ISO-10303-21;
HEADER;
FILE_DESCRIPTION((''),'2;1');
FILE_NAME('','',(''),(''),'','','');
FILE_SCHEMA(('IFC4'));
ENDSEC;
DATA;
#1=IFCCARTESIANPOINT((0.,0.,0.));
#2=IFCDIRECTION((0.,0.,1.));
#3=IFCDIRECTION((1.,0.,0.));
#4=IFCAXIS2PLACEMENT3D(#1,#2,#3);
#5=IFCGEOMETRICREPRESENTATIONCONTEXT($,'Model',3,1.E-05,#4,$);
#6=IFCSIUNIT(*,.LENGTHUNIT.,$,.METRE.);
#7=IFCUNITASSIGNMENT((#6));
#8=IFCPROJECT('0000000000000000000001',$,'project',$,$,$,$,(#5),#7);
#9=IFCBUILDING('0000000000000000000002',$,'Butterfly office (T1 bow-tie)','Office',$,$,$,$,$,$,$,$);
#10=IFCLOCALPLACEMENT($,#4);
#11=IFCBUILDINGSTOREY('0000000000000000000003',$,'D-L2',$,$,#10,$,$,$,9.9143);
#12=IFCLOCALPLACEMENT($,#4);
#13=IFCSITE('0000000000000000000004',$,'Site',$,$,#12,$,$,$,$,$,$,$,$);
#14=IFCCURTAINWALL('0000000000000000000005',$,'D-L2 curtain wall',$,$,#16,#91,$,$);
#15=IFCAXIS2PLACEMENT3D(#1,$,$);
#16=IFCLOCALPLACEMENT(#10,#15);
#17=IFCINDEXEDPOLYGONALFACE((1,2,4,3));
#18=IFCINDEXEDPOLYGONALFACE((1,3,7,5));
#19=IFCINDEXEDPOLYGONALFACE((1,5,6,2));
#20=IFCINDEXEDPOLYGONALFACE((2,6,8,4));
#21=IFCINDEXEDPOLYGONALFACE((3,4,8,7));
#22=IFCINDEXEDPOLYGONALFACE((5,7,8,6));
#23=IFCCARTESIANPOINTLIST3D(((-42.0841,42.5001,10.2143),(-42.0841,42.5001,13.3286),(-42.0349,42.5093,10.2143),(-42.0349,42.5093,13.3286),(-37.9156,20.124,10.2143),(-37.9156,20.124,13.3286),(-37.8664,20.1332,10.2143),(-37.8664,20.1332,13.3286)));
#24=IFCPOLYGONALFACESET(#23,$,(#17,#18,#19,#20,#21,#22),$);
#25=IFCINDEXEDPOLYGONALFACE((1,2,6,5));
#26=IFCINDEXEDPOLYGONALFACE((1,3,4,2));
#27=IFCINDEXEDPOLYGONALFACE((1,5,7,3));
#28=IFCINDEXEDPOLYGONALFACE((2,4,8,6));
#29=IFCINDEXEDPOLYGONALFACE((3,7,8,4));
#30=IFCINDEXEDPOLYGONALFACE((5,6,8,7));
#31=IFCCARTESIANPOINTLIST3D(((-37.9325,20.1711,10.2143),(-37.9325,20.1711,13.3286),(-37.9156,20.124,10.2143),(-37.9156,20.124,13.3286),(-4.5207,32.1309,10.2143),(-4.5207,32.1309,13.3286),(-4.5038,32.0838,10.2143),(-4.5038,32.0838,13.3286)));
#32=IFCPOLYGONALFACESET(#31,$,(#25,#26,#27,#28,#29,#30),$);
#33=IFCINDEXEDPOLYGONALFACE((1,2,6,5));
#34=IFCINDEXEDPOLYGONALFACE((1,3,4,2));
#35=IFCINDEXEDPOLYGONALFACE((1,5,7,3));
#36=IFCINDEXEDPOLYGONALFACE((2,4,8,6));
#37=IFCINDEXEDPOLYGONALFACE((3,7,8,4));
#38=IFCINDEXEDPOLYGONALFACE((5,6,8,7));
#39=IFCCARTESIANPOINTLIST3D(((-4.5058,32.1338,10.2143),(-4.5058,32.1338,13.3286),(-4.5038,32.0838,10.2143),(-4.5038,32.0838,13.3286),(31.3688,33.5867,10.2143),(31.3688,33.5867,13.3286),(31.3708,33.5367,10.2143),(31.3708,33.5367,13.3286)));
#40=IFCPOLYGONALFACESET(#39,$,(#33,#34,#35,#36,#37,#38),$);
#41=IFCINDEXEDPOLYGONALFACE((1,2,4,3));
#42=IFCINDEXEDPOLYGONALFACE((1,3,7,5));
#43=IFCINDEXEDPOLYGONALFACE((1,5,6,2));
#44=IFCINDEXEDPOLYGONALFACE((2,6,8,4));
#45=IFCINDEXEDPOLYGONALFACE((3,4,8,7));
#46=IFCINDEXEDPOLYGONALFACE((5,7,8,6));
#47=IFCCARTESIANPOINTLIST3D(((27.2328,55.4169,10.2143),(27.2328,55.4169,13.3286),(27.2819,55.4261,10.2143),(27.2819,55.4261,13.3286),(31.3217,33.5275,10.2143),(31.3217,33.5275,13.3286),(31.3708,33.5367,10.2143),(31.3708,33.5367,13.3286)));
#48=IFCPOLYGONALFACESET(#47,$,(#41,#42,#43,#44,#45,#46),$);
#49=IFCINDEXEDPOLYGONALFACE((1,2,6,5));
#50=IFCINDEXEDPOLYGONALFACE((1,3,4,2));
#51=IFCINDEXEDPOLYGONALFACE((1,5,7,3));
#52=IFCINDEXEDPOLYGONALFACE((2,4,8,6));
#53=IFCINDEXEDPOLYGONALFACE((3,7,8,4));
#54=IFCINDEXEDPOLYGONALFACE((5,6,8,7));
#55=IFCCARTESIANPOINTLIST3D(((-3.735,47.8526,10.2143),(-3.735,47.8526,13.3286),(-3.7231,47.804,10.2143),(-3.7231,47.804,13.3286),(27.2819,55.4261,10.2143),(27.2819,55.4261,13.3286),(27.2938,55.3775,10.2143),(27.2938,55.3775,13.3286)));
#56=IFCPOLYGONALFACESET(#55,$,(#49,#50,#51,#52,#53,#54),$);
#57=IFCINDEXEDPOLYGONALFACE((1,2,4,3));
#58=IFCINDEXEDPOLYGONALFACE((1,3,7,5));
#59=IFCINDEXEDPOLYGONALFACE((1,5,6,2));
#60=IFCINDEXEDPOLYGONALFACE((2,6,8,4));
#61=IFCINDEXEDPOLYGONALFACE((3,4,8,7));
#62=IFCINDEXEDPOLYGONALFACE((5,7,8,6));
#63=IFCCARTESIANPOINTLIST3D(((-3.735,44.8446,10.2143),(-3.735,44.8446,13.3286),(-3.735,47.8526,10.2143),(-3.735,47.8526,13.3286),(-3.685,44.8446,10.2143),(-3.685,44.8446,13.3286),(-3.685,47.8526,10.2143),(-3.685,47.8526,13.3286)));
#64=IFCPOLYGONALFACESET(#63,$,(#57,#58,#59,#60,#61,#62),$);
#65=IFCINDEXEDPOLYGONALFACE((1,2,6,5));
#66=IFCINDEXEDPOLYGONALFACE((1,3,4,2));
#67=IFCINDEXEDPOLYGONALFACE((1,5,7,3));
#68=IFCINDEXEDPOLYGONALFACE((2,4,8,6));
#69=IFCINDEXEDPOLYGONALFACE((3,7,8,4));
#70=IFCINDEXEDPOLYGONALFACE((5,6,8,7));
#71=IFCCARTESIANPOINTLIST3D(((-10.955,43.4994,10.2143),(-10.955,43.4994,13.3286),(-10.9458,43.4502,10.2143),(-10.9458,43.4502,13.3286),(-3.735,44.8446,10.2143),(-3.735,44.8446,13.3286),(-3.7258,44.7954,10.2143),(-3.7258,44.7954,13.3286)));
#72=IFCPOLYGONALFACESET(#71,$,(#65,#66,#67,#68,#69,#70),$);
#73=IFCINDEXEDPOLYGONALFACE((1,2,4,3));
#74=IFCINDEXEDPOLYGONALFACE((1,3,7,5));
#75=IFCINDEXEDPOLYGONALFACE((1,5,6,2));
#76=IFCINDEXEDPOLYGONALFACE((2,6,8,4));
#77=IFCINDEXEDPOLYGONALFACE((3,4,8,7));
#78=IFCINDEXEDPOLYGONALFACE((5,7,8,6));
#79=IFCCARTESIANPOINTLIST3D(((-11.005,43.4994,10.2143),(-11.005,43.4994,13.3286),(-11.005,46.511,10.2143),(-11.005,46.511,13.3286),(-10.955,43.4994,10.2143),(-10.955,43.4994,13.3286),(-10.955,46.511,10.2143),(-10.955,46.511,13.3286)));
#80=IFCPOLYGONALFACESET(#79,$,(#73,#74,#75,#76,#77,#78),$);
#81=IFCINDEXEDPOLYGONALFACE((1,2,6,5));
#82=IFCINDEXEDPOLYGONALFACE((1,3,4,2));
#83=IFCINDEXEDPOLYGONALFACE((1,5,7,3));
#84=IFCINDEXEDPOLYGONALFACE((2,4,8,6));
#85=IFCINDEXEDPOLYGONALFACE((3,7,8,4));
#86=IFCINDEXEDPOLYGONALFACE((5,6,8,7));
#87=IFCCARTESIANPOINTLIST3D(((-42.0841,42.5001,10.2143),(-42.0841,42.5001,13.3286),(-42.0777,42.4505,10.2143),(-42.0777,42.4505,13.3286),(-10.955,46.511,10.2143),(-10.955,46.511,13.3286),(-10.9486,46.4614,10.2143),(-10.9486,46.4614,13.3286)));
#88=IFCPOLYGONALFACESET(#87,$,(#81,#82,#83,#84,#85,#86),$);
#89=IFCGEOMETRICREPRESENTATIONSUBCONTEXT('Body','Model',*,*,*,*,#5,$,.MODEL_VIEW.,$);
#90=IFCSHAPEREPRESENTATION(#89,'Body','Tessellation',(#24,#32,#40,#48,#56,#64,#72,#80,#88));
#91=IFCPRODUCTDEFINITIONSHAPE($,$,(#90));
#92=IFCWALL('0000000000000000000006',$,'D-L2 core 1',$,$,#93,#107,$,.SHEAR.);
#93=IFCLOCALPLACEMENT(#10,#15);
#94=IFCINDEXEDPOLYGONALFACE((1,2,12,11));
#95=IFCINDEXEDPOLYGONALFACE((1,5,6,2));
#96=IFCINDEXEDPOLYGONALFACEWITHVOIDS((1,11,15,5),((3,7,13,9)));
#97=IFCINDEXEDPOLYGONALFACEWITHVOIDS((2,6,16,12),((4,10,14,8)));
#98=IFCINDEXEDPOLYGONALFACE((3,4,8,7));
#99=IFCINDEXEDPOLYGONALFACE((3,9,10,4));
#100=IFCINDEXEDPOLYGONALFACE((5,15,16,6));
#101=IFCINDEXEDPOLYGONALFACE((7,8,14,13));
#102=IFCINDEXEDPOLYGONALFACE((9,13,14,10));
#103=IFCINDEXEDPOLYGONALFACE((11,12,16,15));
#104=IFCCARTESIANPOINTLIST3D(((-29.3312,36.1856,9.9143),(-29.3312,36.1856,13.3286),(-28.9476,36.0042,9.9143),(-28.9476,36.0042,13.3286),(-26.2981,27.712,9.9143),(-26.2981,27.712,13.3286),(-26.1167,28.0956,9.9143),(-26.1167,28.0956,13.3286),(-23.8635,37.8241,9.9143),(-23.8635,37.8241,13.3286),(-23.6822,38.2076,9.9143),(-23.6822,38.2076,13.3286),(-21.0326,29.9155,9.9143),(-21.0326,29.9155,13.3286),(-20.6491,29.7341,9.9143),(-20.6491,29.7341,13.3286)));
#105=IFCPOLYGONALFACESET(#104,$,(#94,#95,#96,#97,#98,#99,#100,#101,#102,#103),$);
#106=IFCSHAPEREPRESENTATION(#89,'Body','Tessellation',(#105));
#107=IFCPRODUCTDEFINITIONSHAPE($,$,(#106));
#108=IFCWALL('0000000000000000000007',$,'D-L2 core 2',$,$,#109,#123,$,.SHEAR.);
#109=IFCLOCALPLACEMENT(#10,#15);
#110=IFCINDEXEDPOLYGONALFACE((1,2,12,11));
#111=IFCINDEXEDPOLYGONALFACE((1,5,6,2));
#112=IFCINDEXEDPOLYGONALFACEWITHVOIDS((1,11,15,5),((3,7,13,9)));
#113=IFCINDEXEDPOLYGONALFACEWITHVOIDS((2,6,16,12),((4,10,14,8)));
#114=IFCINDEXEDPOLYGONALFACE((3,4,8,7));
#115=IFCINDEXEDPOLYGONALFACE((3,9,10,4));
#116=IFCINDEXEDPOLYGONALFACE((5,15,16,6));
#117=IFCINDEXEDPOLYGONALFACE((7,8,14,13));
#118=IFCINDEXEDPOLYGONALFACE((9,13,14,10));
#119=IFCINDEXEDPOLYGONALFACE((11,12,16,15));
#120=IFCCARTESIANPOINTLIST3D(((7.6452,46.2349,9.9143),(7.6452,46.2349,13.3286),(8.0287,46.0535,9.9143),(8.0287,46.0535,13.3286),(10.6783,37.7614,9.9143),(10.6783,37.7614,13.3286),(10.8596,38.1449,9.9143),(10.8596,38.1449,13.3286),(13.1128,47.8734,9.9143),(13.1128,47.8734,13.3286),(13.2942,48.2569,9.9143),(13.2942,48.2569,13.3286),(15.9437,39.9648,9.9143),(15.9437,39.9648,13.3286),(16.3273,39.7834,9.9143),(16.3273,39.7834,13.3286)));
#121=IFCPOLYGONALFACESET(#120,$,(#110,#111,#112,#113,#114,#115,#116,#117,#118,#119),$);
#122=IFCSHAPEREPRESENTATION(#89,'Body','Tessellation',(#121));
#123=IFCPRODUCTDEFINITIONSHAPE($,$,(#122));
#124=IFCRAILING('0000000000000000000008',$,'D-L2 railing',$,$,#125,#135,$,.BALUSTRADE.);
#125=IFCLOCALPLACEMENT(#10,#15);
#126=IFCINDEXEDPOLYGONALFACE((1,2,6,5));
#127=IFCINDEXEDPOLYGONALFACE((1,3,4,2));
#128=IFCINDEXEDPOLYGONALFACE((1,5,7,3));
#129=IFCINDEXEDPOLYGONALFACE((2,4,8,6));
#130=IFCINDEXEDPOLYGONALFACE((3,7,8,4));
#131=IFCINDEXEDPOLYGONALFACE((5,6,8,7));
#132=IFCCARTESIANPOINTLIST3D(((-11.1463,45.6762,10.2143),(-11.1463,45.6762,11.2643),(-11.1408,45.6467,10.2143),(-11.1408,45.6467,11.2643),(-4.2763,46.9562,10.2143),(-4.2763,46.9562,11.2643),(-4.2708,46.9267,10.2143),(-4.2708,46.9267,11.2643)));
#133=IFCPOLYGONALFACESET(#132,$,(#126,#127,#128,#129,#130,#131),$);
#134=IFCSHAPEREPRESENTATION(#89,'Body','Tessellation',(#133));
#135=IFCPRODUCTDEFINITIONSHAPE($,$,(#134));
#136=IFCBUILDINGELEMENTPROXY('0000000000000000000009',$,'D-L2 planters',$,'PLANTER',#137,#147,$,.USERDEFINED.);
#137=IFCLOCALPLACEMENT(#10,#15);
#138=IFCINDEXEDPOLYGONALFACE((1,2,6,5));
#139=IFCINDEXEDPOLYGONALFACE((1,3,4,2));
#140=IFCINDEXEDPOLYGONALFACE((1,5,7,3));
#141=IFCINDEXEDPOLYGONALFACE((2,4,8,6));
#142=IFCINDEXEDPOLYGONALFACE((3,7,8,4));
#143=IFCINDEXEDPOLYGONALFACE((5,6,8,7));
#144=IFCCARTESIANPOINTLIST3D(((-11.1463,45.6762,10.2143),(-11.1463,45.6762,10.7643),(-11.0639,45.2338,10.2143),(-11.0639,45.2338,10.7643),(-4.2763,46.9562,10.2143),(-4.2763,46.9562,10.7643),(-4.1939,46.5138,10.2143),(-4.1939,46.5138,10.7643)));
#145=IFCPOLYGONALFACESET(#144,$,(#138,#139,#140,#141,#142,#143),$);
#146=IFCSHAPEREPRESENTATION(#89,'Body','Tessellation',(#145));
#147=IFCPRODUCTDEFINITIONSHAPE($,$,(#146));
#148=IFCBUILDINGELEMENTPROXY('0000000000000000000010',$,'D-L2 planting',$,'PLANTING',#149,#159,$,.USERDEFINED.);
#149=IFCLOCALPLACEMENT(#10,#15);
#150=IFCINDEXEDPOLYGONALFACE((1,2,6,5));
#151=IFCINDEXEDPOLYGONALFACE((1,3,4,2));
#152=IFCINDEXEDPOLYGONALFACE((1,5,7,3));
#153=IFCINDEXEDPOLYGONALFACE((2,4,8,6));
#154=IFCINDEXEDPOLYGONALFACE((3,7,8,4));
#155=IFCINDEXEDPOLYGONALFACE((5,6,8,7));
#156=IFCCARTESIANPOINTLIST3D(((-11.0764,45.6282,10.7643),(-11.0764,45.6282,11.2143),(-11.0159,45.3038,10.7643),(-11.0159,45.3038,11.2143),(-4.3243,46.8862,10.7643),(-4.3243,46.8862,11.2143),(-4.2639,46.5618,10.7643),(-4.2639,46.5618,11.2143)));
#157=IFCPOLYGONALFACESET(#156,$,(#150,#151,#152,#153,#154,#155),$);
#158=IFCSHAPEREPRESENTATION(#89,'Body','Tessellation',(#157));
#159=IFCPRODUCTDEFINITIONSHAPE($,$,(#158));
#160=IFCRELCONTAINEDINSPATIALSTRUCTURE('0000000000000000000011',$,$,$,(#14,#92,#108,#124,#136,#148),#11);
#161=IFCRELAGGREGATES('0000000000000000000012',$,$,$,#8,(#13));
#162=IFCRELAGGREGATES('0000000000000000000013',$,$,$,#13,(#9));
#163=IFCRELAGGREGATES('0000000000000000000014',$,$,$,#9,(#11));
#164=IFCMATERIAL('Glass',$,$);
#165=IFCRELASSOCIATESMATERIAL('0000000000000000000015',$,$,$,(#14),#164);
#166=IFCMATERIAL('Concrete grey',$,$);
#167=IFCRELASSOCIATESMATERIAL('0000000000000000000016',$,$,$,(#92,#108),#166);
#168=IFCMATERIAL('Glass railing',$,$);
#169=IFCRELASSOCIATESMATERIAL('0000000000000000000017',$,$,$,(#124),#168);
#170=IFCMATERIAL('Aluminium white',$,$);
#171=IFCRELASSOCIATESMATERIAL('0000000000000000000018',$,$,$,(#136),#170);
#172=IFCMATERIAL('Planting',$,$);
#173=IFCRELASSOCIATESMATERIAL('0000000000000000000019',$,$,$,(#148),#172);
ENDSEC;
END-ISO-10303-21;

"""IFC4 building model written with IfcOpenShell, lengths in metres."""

from ifc_helpers import new_model, si_unit, frame, origin_with_axes, place, context, subcontext, project, spatial, polyline, outline, extrude, material, element, save


model = new_model("IFC4")

# Units and contexts
model_context = context("Model", 3, precision=1e-05, world=origin_with_axes())
body_context = subcontext(model_context, "Body", "Model", "MODEL_VIEW")
ifc_project = project(units=[si_unit("LENGTHUNIT", "METRE")], contexts=[model_context])

# Site, building, storey
site_placement = place(None, origin_with_axes())
site = spatial("IfcSite", under=ifc_project, at=site_placement, Name="Site")
building = spatial("IfcBuilding", under=site, Name="Butterfly office (T1 bow-tie)", Description="Office")
storey_placement = place(None, origin_with_axes())
storey = spatial("IfcBuildingStorey", under=building, at=storey_placement, Name="D-L2", Elevation=9.9143)

# Shared definitions
ifc_material_1 = material(Name="Concrete grey")

# Shared definitions
ifc_material_2 = material(Name="Aluminium white")

# Curtain wall
ifc_material_3 = material(Name="Glass")
curtain_wall_placement = place(storey_placement, origin_with_axes())
element("IfcCurtainWall", 1, at=curtain_wall_placement, inside=storey, material=ifc_material_3, Name="D-L2 curtain wall", context=body_context, shape_type="SweptSolid", body=[
    extrude(outline(polyline([(-42.0841, 42.5001), (-37.9156, 20.124), (-37.8664, 20.1332), (-42.0349, 42.5093), (-42.0841, 42.5001)])), frame((0.0, 0.0, 10.2143), z_axis=(0.0, 0.0, 1.0), x_axis=(1.0, 0.0, 0.0)), (0.0, 0.0, 1.0), 3.1143),
    extrude(outline(polyline([(-37.9156, 20.124), (-4.5038, 32.0838), (-4.5207, 32.1309), (-37.9325, 20.1711), (-37.9156, 20.124)])), frame((0.0, 0.0, 10.2143), z_axis=(0.0, 0.0, 1.0), x_axis=(1.0, 0.0, 0.0)), (0.0, 0.0, 1.0), 3.1143),
    extrude(outline(polyline([(-4.5038, 32.0838), (31.3708, 33.5367), (31.3688, 33.5867), (-4.5058, 32.1338), (-4.5038, 32.0838)])), frame((0.0, 0.0, 10.2143), z_axis=(0.0, 0.0, 1.0), x_axis=(1.0, 0.0, 0.0)), (0.0, 0.0, 1.0), 3.1143),
    extrude(outline(polyline([(31.3708, 33.5367), (27.2819, 55.4261), (27.2328, 55.4169), (31.3217, 33.5275), (31.3708, 33.5367)])), frame((0.0, 0.0, 10.2143), z_axis=(0.0, 0.0, 1.0), x_axis=(1.0, 0.0, 0.0)), (0.0, 0.0, 1.0), 3.1143),
    extrude(outline(polyline([(27.2819, 55.4261), (-3.735, 47.8526), (-3.7231, 47.804), (27.2938, 55.3775), (27.2819, 55.4261)])), frame((0.0, 0.0, 10.2143), z_axis=(0.0, 0.0, 1.0), x_axis=(1.0, 0.0, 0.0)), (0.0, 0.0, 1.0), 3.1143),
    extrude(outline(polyline([(-3.735, 47.8526), (-3.735, 44.8446), (-3.685, 44.8446), (-3.685, 47.8526), (-3.735, 47.8526)])), frame((0.0, 0.0, 10.2143), z_axis=(0.0, 0.0, 1.0), x_axis=(1.0, 0.0, 0.0)), (0.0, 0.0, 1.0), 3.1143),
    extrude(outline(polyline([(-3.735, 44.8446), (-10.955, 43.4994), (-10.9458, 43.4502), (-3.7258, 44.7954), (-3.735, 44.8446)])), frame((0.0, 0.0, 10.2143), z_axis=(0.0, 0.0, 1.0), x_axis=(1.0, 0.0, 0.0)), (0.0, 0.0, 1.0), 3.1143),
    extrude(outline(polyline([(-10.955, 43.4994), (-10.955, 46.511), (-11.005, 46.511), (-11.005, 43.4994), (-10.955, 43.4994)])), frame((0.0, 0.0, 10.2143), z_axis=(0.0, 0.0, 1.0), x_axis=(1.0, 0.0, 0.0)), (0.0, 0.0, 1.0), 3.1143),
    extrude(outline(polyline([(-10.955, 46.511), (-42.0841, 42.5001), (-42.0777, 42.4505), (-10.9486, 46.4614), (-10.955, 46.511)])), frame((0.0, 0.0, 10.2143), z_axis=(0.0, 0.0, 1.0), x_axis=(1.0, 0.0, 0.0)), (0.0, 0.0, 1.0), 3.1143),
])

# Walls
wall_1_placement = place(storey_placement, origin_with_axes())
element("IfcWall", 2, at=wall_1_placement, inside=storey, material=ifc_material_1, Name="D-L2 core 1", PredefinedType="SHEAR", context=body_context, shape_type="SweptSolid", body=[
    extrude(outline(polyline([(-26.2981, 27.712), (-20.6491, 29.7341), (-23.6822, 38.2076), (-29.3312, 36.1856), (-26.2981, 27.712)]), holes=[polyline([(-26.1167, 28.0956), (-21.0326, 29.9155), (-23.8635, 37.8241), (-28.9476, 36.0042), (-26.1167, 28.0956)])]), frame((0.0, 0.0, 9.9143), z_axis=(0.0, 0.0, 1.0), x_axis=(1.0, 0.0, 0.0)), (0.0, 0.0, 1.0), 3.4143),
])
wall_2_placement = place(storey_placement, origin_with_axes())
element("IfcWall", 3, at=wall_2_placement, inside=storey, material=ifc_material_1, Name="D-L2 core 2", PredefinedType="SHEAR", context=body_context, shape_type="SweptSolid", body=[
    extrude(outline(polyline([(10.6783, 37.7614), (16.3273, 39.7834), (13.2942, 48.2569), (7.6452, 46.2349), (10.6783, 37.7614)]), holes=[polyline([(10.8596, 38.1449), (15.9437, 39.9648), (13.1128, 47.8734), (8.0287, 46.0535), (10.8596, 38.1449)])]), frame((0.0, 0.0, 9.9143), z_axis=(0.0, 0.0, 1.0), x_axis=(1.0, 0.0, 0.0)), (0.0, 0.0, 1.0), 3.4143),
])

# Railing
ifc_material_4 = material(Name="Glass railing")
railing_placement = place(storey_placement, origin_with_axes())
element("IfcRailing", 4, at=railing_placement, inside=storey, material=ifc_material_4, Name="D-L2 railing", PredefinedType="BALUSTRADE", context=body_context, shape_type="SweptSolid", body=[
    extrude(outline(polyline([(-4.2763, 46.9562), (-11.1463, 45.6762), (-11.1408, 45.6467), (-4.2708, 46.9267), (-4.2763, 46.9562)])), frame((0.0, 0.0, 10.2143), z_axis=(0.0, 0.0, 1.0), x_axis=(1.0, 0.0, 0.0)), (0.0, 0.0, 1.0), 1.05),
])

# Building element proxies
proxy_1_placement = place(storey_placement, origin_with_axes())
element("IfcBuildingElementProxy", 5, at=proxy_1_placement, inside=storey, material=ifc_material_2, Name="D-L2 planters", ObjectType="PLANTER", PredefinedType="USERDEFINED", context=body_context, shape_type="SweptSolid", body=[
    extrude(outline(polyline([(-4.2763, 46.9562), (-11.1463, 45.6762), (-11.0639, 45.2338), (-4.1939, 46.5138), (-4.2763, 46.9562)])), frame((0.0, 0.0, 10.2143), z_axis=(0.0, 0.0, 1.0), x_axis=(1.0, 0.0, 0.0)), (0.0, 0.0, 1.0), 0.55),
])
ifc_material_5 = material(Name="Planting")
proxy_2_placement = place(storey_placement, origin_with_axes())
element("IfcBuildingElementProxy", 6, at=proxy_2_placement, inside=storey, material=ifc_material_5, Name="D-L2 planting", ObjectType="PLANTING", PredefinedType="USERDEFINED", context=body_context, shape_type="SweptSolid", body=[
    extrude(outline(polyline([(-4.3243, 46.8862), (-11.0764, 45.6282), (-11.0159, 45.3038), (-4.2639, 46.5618), (-4.3243, 46.8862)])), frame((0.0, 0.0, 10.7643), z_axis=(0.0, 0.0, 1.0), x_axis=(1.0, 0.0, 0.0)), (0.0, 0.0, 1.0), 0.45),
])

save(model, "model.ifc")
